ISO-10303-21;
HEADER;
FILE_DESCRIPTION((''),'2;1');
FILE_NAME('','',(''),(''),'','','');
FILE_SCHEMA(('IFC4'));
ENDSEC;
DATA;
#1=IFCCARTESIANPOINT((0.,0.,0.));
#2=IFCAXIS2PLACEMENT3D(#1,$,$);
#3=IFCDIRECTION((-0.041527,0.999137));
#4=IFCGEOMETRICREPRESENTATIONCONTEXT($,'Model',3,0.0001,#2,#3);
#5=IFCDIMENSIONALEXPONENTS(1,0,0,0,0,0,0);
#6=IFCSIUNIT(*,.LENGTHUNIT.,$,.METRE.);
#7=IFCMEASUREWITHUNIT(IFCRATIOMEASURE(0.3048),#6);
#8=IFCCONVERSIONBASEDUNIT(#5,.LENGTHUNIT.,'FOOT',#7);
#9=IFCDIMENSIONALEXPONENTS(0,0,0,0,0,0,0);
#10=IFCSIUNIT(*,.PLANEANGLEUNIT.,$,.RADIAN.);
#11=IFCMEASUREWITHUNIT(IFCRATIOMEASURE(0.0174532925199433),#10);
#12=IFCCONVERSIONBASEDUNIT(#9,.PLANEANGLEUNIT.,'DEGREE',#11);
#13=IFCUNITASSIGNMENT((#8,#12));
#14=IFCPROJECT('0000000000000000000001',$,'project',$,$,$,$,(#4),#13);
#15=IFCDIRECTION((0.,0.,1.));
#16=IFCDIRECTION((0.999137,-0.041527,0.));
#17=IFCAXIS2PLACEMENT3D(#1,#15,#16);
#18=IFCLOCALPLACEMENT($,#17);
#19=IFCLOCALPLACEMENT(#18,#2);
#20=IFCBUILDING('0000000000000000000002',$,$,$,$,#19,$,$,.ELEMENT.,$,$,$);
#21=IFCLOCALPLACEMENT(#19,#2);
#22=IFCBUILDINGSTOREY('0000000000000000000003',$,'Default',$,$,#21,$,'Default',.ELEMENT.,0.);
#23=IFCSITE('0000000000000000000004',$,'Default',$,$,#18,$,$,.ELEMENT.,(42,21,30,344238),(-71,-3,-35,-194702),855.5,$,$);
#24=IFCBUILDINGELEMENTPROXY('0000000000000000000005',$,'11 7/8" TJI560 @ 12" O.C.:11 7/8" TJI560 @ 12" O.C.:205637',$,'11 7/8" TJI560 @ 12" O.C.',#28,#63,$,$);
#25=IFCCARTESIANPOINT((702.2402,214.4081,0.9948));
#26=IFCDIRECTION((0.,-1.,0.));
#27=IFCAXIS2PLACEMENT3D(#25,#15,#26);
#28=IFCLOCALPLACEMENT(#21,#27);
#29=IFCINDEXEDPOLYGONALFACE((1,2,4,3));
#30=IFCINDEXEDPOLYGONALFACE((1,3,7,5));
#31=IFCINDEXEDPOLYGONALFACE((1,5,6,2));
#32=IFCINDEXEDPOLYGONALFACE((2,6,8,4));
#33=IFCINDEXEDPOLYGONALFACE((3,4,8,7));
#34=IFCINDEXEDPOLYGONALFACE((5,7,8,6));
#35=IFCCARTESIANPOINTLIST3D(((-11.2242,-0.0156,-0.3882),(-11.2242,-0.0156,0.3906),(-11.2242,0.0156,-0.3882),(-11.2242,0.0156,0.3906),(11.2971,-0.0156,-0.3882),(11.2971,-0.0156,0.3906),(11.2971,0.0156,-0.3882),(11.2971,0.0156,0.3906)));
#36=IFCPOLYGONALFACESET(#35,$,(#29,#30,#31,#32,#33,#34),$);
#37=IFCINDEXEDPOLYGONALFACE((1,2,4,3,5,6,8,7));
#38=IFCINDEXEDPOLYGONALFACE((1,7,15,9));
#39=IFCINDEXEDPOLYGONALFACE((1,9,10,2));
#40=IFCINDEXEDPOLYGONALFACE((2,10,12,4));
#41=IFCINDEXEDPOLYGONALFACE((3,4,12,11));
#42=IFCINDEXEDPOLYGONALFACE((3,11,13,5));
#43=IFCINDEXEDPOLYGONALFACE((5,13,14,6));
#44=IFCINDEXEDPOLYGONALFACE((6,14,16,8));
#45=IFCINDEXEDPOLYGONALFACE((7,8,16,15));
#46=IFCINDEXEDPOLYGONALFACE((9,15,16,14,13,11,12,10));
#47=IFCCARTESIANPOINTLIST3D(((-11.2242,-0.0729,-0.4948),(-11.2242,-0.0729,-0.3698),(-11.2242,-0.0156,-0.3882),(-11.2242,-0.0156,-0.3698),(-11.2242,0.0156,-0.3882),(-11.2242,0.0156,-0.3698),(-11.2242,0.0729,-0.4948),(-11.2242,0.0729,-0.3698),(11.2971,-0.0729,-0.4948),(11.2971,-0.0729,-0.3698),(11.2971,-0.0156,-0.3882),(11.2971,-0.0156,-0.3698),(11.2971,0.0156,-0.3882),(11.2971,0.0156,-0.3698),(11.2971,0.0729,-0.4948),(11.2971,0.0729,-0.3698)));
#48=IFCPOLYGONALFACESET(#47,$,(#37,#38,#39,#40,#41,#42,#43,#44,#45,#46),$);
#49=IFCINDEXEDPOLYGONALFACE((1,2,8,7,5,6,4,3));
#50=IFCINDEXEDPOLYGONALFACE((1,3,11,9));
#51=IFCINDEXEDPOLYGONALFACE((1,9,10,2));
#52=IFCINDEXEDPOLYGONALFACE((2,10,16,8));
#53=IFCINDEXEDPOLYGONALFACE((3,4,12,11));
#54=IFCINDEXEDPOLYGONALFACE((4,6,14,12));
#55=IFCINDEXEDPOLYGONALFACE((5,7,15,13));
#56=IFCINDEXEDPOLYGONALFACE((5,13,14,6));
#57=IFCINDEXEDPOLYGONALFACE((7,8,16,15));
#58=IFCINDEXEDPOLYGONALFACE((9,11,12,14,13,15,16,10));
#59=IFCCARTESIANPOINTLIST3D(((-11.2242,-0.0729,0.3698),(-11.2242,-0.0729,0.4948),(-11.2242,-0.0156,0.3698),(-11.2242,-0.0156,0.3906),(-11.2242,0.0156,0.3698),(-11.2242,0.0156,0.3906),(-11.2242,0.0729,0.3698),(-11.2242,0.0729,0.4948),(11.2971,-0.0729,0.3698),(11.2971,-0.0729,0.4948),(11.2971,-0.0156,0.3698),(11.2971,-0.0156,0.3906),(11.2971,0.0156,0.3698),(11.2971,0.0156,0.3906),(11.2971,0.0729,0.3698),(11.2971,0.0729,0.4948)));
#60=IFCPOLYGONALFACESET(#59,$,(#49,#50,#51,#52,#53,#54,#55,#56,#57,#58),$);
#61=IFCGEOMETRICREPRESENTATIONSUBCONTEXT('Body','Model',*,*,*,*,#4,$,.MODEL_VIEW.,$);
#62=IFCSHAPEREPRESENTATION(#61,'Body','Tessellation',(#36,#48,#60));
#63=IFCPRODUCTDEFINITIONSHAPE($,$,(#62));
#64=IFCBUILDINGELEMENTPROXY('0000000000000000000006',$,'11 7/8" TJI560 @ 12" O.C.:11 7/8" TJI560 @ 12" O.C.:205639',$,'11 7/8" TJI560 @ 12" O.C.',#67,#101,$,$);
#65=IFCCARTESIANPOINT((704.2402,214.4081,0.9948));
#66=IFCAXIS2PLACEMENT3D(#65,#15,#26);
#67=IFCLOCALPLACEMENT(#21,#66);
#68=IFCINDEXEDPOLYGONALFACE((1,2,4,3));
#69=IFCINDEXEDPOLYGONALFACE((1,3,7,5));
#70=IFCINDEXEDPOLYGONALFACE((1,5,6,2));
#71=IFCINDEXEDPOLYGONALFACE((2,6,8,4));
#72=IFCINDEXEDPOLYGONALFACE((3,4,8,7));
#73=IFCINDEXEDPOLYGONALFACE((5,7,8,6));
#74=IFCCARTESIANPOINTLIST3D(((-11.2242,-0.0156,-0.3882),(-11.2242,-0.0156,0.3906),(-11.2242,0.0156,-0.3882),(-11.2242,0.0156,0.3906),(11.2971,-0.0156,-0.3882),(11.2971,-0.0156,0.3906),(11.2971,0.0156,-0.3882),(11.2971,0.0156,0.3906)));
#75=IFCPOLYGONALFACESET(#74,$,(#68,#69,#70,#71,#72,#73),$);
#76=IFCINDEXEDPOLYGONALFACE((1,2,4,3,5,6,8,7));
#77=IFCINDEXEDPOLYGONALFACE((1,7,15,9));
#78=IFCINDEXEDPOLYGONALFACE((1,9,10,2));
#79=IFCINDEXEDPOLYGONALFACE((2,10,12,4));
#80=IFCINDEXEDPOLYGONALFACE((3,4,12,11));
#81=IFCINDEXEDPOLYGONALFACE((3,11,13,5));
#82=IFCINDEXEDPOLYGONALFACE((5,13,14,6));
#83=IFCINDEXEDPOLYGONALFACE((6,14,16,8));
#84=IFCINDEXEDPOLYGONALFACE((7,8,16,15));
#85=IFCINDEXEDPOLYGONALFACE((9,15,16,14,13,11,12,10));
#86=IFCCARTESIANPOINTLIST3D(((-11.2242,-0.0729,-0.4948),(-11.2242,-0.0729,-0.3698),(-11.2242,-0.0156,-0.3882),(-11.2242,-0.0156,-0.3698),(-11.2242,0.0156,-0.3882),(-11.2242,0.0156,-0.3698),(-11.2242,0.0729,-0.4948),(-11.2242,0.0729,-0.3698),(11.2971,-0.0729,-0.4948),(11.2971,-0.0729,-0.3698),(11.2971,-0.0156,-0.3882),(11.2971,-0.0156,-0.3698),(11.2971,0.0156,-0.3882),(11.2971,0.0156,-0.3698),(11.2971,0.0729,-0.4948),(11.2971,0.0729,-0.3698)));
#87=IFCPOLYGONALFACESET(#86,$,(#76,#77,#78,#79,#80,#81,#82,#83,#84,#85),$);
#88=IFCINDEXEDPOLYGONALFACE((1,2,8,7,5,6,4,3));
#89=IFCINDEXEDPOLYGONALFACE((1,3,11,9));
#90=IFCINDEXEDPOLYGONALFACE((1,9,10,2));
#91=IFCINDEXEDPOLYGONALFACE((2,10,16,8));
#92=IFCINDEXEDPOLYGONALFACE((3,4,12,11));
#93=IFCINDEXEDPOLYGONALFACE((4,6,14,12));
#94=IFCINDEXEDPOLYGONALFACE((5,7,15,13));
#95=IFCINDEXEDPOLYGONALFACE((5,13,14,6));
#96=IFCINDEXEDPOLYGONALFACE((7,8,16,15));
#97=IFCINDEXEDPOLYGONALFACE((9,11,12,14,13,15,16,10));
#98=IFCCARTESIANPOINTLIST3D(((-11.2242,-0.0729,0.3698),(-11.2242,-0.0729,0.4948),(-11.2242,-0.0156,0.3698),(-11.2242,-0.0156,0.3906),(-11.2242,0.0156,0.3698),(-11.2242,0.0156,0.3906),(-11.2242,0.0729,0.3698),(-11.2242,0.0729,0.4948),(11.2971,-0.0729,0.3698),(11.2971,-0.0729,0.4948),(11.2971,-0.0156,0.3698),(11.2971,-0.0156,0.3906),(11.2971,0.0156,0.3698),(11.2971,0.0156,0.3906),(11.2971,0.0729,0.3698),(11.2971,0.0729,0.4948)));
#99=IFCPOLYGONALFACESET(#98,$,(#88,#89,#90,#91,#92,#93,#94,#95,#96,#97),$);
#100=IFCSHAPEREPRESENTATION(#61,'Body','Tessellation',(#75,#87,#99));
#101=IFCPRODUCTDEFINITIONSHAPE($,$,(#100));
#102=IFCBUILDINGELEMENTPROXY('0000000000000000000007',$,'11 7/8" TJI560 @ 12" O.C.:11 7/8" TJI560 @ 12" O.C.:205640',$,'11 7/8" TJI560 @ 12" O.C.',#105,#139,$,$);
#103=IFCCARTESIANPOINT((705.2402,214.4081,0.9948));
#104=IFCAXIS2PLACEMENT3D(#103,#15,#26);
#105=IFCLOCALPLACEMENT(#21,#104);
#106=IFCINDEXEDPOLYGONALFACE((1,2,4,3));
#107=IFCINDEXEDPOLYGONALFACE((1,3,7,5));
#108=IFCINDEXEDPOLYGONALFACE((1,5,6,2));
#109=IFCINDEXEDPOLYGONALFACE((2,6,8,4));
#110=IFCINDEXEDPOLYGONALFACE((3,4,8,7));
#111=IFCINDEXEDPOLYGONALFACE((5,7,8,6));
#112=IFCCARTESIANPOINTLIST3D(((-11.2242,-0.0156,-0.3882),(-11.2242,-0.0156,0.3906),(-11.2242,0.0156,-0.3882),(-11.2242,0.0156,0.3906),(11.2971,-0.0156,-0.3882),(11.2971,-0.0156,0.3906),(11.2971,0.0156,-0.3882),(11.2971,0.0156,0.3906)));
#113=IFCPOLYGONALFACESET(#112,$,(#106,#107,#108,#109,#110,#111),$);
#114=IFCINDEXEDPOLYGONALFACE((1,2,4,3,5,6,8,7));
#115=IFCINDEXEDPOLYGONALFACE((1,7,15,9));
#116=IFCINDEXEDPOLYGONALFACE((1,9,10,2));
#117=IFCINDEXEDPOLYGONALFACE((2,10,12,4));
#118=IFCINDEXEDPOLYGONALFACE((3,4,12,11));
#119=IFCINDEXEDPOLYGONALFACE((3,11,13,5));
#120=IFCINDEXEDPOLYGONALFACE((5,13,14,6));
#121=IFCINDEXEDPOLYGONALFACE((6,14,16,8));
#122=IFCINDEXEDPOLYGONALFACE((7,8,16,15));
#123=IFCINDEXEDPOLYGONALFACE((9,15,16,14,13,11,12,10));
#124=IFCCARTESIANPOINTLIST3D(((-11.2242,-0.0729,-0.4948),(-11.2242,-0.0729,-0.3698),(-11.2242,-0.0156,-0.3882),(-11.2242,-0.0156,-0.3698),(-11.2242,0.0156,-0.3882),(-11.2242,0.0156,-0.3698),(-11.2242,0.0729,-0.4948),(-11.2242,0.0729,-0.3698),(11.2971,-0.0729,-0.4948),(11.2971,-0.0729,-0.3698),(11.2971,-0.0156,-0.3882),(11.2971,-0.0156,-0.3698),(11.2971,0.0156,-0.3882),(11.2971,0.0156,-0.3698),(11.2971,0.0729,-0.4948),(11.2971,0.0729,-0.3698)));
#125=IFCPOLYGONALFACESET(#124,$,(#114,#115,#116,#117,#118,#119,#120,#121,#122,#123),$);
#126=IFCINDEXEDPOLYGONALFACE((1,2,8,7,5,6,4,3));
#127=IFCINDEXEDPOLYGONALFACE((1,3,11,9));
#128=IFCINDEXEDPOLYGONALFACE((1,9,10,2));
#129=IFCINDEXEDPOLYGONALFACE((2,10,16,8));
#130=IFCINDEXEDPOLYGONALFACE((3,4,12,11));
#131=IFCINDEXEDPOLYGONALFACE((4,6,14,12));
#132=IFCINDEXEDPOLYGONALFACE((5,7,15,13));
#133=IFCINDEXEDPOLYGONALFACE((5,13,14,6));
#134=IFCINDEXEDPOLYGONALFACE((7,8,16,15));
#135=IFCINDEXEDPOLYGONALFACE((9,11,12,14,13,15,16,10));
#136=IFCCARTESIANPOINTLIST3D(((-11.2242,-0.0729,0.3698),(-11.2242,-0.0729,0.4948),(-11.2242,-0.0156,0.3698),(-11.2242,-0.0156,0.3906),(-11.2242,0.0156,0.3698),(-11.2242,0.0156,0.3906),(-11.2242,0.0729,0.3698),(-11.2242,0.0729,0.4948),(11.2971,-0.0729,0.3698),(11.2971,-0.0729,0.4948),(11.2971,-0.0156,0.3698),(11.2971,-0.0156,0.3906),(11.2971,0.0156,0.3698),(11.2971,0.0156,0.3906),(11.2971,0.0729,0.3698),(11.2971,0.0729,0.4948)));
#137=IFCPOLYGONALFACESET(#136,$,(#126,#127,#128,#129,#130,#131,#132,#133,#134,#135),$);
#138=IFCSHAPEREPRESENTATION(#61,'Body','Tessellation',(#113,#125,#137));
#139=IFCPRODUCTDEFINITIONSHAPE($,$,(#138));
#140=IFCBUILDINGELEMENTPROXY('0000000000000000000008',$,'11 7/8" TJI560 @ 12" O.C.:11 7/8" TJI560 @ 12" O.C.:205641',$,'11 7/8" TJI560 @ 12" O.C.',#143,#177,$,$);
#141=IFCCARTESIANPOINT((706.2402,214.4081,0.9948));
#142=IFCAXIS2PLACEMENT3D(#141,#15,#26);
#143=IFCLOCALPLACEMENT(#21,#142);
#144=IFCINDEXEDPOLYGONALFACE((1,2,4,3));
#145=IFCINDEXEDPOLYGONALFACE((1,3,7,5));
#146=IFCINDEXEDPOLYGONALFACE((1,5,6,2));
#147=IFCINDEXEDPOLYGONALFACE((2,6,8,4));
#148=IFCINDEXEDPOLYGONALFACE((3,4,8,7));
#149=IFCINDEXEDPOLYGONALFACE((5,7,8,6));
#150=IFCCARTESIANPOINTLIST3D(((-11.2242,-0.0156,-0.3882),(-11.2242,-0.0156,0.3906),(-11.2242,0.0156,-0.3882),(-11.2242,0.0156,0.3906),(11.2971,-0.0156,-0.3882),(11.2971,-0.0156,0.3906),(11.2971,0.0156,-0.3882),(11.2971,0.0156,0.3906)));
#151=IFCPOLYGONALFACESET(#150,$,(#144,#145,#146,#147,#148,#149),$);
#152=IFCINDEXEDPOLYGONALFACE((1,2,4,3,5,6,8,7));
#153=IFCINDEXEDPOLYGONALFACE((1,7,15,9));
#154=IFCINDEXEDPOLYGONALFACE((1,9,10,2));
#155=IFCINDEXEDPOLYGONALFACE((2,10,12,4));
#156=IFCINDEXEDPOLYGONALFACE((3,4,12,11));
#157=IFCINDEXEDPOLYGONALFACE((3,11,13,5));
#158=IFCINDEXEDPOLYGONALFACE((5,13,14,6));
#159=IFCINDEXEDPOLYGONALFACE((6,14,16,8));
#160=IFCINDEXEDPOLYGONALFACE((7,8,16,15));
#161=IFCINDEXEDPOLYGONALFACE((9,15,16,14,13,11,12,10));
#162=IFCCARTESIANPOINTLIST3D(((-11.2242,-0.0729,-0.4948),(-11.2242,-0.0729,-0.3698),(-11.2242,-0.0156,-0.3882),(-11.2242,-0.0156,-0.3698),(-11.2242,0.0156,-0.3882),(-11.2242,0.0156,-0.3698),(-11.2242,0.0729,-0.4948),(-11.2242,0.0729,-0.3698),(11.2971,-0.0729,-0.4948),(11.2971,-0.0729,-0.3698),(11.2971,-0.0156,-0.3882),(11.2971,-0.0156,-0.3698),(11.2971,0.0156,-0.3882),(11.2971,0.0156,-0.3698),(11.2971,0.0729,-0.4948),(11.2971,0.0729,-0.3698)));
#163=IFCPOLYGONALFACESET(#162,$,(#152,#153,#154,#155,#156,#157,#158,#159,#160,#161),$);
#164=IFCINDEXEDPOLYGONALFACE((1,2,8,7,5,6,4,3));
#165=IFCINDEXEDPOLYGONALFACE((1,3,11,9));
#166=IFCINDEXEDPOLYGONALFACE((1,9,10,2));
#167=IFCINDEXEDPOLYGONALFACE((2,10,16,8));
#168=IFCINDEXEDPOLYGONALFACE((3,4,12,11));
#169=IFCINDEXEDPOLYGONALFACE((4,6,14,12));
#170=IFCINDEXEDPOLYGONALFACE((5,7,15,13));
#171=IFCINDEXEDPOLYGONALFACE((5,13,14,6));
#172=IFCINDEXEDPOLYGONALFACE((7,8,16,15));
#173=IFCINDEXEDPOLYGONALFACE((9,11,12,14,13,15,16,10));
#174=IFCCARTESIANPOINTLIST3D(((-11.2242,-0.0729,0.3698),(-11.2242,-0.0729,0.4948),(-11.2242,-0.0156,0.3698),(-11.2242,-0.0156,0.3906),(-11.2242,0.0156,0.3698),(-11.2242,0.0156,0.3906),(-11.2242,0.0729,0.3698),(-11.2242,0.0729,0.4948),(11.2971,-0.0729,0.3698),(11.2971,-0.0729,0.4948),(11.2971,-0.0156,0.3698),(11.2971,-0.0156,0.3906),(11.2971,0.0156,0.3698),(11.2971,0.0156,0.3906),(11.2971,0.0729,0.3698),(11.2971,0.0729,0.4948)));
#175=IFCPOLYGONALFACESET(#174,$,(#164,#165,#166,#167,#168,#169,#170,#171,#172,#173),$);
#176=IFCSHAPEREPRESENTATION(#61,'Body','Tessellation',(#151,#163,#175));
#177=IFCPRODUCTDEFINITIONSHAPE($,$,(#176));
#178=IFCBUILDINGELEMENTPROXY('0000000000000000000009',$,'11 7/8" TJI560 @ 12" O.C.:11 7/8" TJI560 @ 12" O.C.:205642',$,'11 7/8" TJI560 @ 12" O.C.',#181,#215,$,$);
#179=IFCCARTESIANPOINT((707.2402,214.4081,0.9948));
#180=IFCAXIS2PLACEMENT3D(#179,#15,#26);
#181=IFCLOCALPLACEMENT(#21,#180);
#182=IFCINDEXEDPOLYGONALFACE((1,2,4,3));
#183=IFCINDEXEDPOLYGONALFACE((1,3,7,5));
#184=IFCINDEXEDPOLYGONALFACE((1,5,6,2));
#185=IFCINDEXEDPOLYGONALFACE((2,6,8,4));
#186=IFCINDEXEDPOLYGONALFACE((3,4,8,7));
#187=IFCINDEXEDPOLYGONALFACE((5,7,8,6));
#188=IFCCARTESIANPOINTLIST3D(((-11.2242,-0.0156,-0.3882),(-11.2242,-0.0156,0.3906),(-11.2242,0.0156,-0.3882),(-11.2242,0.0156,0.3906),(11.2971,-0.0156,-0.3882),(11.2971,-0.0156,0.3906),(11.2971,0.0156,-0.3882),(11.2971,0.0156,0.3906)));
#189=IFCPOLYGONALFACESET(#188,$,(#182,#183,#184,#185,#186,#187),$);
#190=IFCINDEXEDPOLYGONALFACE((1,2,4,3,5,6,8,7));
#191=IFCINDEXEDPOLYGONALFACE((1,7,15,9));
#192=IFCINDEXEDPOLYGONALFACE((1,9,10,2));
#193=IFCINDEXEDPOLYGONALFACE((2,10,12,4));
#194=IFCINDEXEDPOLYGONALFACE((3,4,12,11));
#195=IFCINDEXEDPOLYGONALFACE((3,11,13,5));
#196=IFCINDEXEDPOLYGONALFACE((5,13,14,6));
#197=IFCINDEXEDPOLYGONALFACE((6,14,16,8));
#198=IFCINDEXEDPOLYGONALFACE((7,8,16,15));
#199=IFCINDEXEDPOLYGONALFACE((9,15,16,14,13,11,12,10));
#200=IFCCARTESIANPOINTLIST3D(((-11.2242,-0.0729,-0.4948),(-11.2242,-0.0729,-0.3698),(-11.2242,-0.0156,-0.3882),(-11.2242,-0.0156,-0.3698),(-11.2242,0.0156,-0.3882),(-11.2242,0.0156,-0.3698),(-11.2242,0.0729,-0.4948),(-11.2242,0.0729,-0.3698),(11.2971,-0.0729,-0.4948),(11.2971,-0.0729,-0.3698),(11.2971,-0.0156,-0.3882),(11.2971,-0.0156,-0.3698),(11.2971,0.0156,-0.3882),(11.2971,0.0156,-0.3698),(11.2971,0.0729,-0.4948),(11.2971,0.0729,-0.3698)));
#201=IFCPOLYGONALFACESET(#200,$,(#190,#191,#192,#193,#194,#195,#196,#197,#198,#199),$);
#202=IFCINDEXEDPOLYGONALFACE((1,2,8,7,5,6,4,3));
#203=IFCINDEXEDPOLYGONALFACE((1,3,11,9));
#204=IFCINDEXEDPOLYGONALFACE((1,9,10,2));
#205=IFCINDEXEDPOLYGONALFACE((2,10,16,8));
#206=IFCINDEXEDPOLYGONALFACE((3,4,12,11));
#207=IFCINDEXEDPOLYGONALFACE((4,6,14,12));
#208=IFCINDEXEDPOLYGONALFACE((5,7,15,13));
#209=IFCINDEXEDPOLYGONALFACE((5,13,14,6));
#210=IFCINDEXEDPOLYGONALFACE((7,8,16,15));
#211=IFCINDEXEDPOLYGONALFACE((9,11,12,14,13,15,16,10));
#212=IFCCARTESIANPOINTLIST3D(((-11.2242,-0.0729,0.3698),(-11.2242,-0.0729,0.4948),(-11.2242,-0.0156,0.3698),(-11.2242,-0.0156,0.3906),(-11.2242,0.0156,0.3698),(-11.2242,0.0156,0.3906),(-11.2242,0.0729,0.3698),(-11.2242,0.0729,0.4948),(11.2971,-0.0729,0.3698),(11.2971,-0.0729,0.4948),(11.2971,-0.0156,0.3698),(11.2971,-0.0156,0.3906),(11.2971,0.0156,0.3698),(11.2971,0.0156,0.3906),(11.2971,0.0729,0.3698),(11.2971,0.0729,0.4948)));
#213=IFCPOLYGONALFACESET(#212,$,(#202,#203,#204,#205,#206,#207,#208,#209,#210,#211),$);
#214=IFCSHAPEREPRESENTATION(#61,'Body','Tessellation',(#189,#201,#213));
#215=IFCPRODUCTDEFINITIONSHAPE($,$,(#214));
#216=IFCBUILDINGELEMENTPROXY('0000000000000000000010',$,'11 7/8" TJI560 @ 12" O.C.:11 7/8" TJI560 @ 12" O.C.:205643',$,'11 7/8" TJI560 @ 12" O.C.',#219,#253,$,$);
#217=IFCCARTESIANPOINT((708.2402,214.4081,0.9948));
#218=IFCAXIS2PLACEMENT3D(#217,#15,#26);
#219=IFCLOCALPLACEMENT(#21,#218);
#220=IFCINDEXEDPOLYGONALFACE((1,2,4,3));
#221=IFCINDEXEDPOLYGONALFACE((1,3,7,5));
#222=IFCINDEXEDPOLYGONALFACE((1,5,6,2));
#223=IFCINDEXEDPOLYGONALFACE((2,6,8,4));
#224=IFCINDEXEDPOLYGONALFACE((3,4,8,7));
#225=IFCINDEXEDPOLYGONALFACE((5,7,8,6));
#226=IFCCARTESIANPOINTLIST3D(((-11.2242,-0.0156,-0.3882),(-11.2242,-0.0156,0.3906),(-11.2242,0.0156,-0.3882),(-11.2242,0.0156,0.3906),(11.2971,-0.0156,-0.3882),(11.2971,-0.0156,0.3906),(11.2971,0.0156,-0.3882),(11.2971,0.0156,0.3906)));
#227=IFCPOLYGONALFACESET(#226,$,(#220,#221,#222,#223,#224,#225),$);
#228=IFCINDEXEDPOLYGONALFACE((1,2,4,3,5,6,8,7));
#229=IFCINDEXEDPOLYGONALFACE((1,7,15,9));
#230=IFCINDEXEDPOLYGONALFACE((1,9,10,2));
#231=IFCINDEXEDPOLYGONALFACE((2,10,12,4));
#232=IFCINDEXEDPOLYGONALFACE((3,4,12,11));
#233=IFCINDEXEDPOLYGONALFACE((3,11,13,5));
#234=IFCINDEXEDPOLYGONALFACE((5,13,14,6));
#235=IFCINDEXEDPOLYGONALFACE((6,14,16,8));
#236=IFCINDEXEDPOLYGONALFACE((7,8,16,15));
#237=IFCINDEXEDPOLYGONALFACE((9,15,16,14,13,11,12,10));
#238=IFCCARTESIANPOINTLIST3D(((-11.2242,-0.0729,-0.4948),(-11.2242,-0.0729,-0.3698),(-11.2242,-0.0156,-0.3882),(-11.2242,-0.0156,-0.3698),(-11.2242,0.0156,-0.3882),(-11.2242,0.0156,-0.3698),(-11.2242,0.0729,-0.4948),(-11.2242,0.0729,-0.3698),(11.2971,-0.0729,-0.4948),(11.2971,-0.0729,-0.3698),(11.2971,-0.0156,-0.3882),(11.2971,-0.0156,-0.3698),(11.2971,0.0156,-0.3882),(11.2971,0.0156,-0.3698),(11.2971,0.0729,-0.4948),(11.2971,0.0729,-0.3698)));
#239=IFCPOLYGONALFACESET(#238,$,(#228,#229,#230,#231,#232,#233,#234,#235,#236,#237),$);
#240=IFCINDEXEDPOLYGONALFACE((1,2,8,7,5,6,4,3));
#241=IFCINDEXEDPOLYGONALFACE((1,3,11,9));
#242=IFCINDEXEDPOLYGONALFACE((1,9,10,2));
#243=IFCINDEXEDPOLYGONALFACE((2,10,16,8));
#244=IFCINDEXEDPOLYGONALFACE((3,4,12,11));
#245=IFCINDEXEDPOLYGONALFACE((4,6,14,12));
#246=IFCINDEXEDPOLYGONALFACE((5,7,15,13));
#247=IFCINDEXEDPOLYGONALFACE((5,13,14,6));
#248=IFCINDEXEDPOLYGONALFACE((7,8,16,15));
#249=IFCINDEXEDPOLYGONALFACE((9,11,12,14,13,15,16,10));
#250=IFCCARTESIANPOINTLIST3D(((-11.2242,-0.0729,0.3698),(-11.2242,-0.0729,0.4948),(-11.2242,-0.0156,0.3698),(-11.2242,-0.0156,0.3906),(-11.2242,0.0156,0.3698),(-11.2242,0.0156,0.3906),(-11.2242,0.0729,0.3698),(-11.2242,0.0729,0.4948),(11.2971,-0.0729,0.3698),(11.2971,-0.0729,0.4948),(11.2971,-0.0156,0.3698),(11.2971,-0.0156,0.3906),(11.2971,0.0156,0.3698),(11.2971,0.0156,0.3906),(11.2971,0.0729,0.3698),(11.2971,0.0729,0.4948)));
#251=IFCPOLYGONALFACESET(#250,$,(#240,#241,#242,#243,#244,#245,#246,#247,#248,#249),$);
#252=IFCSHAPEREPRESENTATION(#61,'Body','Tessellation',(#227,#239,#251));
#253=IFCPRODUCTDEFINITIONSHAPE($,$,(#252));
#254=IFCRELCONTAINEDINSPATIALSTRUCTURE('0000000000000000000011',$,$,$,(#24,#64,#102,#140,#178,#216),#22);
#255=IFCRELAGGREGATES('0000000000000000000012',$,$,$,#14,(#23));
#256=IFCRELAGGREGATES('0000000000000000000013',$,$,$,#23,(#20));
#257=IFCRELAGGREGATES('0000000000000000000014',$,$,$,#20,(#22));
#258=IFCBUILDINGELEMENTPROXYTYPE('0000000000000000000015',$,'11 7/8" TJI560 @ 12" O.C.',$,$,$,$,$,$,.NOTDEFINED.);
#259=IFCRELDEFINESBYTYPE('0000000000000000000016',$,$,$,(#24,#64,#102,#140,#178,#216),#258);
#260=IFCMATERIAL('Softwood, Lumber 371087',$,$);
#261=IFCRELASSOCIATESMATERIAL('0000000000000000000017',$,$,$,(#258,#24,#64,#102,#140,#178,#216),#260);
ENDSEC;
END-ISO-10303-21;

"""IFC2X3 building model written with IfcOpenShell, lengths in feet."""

from ifc_helpers import new_model, entity, si_unit, converted_unit, direction, frame, origin, origin_2d_with_axis, place, context, subcontext, project, spatial, polyline, rectangle, outline, extrude, source, transform, mapped, material, type_object, type_shapes, element, save


model = new_model("IFC2X3")

# Units and contexts
model_context = context("Model", 3, precision=0.0001, world=origin(), true_north=direction((-0.041527, 0.999137)))
body_context = subcontext(model_context, "Body", "Model", "MODEL_VIEW")
ifc_project = project(units=[converted_unit("LENGTHUNIT", "FOOT", entity("IfcRatioMeasure", 0.3048), si_unit("LENGTHUNIT", "METRE"), dimensions=[1, 0, 0, 0, 0, 0, 0]), converted_unit("PLANEANGLEUNIT", "DEGREE", entity("IfcRatioMeasure", 0.0174532925199433), si_unit("PLANEANGLEUNIT", "RADIAN"), dimensions=[0, 0, 0, 0, 0, 0, 0])], contexts=[model_context])

# Site, building, storey
site_placement = place(None, frame((0.0, 0.0, 0.0), z_axis=(0.0, 0.0, 1.0), x_axis=(0.999137, -0.041527, 0.0)))
site = spatial("IfcSite", under=ifc_project, at=site_placement, Name="Default", CompositionType="ELEMENT", RefLatitude=(42, 21, 30, 344238), RefLongitude=(-71, -3, -35, -194702), RefElevation=855.5)
building_placement = place(site_placement, origin())
building = spatial("IfcBuilding", under=site, at=building_placement, CompositionType="ELEMENT")
storey_placement = place(building_placement, origin())
storey = spatial("IfcBuildingStorey", under=building, at=storey_placement, Name="Default", LongName="Default", CompositionType="ELEMENT", Elevation=0.0)

# Building element proxies
ifc_material = material(Name="Softwood, Lumber 371087")
building_element_proxy_type_1 = type_object("IfcBuildingElementProxyType", Name="11 7/8\" TJI560 @ 12\" O.C.", PredefinedType="NOTDEFINED", material=ifc_material)
shared_shape_1 = source(origin(), body_context, "Body", "SweptSolid", [
    extrude(rectangle(XDim=22.5212, YDim=0.0313, at=origin_2d_with_axis()), frame((0.0365, 0.0, -0.3882), z_axis=(0.0, 0.0, 1.0), x_axis=(-1.0, 0.0, 0.0)), (0.0, 0.0, 1.0), 0.7788),
    extrude(outline(polyline([(-0.0891, -0.0729), (0.0359, -0.0729), (0.0359, -0.0156), (0.0174, -0.0156), (0.0174, 0.0156), (0.0359, 0.0156), (0.0359, 0.0729), (-0.0891, 0.0729), (-0.0891, -0.0729)])), frame((-11.2242, 0.0, -0.4056), z_axis=(1.0, 0.0, 0.0), x_axis=(0.0, 0.0, 1.0)), (0.0, 0.0, 1.0), 22.5212),
    extrude(outline(polyline([(-0.0729, -0.0885), (0.0729, -0.0885), (0.0729, 0.0365), (0.0156, 0.0365), (0.0156, 0.0156), (-0.0156, 0.0156), (-0.0156, 0.0365), (-0.0729, 0.0365), (-0.0729, -0.0885)])), frame((-11.2242, 0.0, 0.4062), z_axis=(1.0, 0.0, 0.0), x_axis=(0.0, -1.0, 0.0)), (0.0, 0.0, 1.0), 22.5212),
])
type_shapes(building_element_proxy_type_1, [shared_shape_1])
for number, where, z_axis, x_axis, name in (
    (1, (702.2402, 214.4081, 0.9948), (0.0, 0.0, 1.0), (0.0, -1.0, 0.0), "11 7/8\" TJI560 @ 12\" O.C.:11 7/8\" TJI560 @ 12\" O.C.:205637"),
    (2, (704.2402, 214.4081, 0.9948), (0.0, 0.0, 1.0), (0.0, -1.0, 0.0), "11 7/8\" TJI560 @ 12\" O.C.:11 7/8\" TJI560 @ 12\" O.C.:205639"),
    (3, (705.2402, 214.4081, 0.9948), (0.0, 0.0, 1.0), (0.0, -1.0, 0.0), "11 7/8\" TJI560 @ 12\" O.C.:11 7/8\" TJI560 @ 12\" O.C.:205640"),
    (4, (706.2402, 214.4081, 0.9948), (0.0, 0.0, 1.0), (0.0, -1.0, 0.0), "11 7/8\" TJI560 @ 12\" O.C.:11 7/8\" TJI560 @ 12\" O.C.:205641"),
    (5, (707.2402, 214.4081, 0.9948), (0.0, 0.0, 1.0), (0.0, -1.0, 0.0), "11 7/8\" TJI560 @ 12\" O.C.:11 7/8\" TJI560 @ 12\" O.C.:205642"),
    (6, (708.2402, 214.4081, 0.9948), (0.0, 0.0, 1.0), (0.0, -1.0, 0.0), "11 7/8\" TJI560 @ 12\" O.C.:11 7/8\" TJI560 @ 12\" O.C.:205643"),
):
    element("IfcBuildingElementProxy", number, at=place(storey_placement, frame(where, z_axis=z_axis, x_axis=x_axis)), inside=storey, type_object=building_element_proxy_type_1, material=ifc_material, Name=name, ObjectType="11 7/8\" TJI560 @ 12\" O.C.", context=body_context, shape_type="MappedRepresentation", body=[
        mapped(shared_shape_1, transform((0.0, 0.0, 0.0), scale=1.0)),
    ])

save(model, "model.ifc")
